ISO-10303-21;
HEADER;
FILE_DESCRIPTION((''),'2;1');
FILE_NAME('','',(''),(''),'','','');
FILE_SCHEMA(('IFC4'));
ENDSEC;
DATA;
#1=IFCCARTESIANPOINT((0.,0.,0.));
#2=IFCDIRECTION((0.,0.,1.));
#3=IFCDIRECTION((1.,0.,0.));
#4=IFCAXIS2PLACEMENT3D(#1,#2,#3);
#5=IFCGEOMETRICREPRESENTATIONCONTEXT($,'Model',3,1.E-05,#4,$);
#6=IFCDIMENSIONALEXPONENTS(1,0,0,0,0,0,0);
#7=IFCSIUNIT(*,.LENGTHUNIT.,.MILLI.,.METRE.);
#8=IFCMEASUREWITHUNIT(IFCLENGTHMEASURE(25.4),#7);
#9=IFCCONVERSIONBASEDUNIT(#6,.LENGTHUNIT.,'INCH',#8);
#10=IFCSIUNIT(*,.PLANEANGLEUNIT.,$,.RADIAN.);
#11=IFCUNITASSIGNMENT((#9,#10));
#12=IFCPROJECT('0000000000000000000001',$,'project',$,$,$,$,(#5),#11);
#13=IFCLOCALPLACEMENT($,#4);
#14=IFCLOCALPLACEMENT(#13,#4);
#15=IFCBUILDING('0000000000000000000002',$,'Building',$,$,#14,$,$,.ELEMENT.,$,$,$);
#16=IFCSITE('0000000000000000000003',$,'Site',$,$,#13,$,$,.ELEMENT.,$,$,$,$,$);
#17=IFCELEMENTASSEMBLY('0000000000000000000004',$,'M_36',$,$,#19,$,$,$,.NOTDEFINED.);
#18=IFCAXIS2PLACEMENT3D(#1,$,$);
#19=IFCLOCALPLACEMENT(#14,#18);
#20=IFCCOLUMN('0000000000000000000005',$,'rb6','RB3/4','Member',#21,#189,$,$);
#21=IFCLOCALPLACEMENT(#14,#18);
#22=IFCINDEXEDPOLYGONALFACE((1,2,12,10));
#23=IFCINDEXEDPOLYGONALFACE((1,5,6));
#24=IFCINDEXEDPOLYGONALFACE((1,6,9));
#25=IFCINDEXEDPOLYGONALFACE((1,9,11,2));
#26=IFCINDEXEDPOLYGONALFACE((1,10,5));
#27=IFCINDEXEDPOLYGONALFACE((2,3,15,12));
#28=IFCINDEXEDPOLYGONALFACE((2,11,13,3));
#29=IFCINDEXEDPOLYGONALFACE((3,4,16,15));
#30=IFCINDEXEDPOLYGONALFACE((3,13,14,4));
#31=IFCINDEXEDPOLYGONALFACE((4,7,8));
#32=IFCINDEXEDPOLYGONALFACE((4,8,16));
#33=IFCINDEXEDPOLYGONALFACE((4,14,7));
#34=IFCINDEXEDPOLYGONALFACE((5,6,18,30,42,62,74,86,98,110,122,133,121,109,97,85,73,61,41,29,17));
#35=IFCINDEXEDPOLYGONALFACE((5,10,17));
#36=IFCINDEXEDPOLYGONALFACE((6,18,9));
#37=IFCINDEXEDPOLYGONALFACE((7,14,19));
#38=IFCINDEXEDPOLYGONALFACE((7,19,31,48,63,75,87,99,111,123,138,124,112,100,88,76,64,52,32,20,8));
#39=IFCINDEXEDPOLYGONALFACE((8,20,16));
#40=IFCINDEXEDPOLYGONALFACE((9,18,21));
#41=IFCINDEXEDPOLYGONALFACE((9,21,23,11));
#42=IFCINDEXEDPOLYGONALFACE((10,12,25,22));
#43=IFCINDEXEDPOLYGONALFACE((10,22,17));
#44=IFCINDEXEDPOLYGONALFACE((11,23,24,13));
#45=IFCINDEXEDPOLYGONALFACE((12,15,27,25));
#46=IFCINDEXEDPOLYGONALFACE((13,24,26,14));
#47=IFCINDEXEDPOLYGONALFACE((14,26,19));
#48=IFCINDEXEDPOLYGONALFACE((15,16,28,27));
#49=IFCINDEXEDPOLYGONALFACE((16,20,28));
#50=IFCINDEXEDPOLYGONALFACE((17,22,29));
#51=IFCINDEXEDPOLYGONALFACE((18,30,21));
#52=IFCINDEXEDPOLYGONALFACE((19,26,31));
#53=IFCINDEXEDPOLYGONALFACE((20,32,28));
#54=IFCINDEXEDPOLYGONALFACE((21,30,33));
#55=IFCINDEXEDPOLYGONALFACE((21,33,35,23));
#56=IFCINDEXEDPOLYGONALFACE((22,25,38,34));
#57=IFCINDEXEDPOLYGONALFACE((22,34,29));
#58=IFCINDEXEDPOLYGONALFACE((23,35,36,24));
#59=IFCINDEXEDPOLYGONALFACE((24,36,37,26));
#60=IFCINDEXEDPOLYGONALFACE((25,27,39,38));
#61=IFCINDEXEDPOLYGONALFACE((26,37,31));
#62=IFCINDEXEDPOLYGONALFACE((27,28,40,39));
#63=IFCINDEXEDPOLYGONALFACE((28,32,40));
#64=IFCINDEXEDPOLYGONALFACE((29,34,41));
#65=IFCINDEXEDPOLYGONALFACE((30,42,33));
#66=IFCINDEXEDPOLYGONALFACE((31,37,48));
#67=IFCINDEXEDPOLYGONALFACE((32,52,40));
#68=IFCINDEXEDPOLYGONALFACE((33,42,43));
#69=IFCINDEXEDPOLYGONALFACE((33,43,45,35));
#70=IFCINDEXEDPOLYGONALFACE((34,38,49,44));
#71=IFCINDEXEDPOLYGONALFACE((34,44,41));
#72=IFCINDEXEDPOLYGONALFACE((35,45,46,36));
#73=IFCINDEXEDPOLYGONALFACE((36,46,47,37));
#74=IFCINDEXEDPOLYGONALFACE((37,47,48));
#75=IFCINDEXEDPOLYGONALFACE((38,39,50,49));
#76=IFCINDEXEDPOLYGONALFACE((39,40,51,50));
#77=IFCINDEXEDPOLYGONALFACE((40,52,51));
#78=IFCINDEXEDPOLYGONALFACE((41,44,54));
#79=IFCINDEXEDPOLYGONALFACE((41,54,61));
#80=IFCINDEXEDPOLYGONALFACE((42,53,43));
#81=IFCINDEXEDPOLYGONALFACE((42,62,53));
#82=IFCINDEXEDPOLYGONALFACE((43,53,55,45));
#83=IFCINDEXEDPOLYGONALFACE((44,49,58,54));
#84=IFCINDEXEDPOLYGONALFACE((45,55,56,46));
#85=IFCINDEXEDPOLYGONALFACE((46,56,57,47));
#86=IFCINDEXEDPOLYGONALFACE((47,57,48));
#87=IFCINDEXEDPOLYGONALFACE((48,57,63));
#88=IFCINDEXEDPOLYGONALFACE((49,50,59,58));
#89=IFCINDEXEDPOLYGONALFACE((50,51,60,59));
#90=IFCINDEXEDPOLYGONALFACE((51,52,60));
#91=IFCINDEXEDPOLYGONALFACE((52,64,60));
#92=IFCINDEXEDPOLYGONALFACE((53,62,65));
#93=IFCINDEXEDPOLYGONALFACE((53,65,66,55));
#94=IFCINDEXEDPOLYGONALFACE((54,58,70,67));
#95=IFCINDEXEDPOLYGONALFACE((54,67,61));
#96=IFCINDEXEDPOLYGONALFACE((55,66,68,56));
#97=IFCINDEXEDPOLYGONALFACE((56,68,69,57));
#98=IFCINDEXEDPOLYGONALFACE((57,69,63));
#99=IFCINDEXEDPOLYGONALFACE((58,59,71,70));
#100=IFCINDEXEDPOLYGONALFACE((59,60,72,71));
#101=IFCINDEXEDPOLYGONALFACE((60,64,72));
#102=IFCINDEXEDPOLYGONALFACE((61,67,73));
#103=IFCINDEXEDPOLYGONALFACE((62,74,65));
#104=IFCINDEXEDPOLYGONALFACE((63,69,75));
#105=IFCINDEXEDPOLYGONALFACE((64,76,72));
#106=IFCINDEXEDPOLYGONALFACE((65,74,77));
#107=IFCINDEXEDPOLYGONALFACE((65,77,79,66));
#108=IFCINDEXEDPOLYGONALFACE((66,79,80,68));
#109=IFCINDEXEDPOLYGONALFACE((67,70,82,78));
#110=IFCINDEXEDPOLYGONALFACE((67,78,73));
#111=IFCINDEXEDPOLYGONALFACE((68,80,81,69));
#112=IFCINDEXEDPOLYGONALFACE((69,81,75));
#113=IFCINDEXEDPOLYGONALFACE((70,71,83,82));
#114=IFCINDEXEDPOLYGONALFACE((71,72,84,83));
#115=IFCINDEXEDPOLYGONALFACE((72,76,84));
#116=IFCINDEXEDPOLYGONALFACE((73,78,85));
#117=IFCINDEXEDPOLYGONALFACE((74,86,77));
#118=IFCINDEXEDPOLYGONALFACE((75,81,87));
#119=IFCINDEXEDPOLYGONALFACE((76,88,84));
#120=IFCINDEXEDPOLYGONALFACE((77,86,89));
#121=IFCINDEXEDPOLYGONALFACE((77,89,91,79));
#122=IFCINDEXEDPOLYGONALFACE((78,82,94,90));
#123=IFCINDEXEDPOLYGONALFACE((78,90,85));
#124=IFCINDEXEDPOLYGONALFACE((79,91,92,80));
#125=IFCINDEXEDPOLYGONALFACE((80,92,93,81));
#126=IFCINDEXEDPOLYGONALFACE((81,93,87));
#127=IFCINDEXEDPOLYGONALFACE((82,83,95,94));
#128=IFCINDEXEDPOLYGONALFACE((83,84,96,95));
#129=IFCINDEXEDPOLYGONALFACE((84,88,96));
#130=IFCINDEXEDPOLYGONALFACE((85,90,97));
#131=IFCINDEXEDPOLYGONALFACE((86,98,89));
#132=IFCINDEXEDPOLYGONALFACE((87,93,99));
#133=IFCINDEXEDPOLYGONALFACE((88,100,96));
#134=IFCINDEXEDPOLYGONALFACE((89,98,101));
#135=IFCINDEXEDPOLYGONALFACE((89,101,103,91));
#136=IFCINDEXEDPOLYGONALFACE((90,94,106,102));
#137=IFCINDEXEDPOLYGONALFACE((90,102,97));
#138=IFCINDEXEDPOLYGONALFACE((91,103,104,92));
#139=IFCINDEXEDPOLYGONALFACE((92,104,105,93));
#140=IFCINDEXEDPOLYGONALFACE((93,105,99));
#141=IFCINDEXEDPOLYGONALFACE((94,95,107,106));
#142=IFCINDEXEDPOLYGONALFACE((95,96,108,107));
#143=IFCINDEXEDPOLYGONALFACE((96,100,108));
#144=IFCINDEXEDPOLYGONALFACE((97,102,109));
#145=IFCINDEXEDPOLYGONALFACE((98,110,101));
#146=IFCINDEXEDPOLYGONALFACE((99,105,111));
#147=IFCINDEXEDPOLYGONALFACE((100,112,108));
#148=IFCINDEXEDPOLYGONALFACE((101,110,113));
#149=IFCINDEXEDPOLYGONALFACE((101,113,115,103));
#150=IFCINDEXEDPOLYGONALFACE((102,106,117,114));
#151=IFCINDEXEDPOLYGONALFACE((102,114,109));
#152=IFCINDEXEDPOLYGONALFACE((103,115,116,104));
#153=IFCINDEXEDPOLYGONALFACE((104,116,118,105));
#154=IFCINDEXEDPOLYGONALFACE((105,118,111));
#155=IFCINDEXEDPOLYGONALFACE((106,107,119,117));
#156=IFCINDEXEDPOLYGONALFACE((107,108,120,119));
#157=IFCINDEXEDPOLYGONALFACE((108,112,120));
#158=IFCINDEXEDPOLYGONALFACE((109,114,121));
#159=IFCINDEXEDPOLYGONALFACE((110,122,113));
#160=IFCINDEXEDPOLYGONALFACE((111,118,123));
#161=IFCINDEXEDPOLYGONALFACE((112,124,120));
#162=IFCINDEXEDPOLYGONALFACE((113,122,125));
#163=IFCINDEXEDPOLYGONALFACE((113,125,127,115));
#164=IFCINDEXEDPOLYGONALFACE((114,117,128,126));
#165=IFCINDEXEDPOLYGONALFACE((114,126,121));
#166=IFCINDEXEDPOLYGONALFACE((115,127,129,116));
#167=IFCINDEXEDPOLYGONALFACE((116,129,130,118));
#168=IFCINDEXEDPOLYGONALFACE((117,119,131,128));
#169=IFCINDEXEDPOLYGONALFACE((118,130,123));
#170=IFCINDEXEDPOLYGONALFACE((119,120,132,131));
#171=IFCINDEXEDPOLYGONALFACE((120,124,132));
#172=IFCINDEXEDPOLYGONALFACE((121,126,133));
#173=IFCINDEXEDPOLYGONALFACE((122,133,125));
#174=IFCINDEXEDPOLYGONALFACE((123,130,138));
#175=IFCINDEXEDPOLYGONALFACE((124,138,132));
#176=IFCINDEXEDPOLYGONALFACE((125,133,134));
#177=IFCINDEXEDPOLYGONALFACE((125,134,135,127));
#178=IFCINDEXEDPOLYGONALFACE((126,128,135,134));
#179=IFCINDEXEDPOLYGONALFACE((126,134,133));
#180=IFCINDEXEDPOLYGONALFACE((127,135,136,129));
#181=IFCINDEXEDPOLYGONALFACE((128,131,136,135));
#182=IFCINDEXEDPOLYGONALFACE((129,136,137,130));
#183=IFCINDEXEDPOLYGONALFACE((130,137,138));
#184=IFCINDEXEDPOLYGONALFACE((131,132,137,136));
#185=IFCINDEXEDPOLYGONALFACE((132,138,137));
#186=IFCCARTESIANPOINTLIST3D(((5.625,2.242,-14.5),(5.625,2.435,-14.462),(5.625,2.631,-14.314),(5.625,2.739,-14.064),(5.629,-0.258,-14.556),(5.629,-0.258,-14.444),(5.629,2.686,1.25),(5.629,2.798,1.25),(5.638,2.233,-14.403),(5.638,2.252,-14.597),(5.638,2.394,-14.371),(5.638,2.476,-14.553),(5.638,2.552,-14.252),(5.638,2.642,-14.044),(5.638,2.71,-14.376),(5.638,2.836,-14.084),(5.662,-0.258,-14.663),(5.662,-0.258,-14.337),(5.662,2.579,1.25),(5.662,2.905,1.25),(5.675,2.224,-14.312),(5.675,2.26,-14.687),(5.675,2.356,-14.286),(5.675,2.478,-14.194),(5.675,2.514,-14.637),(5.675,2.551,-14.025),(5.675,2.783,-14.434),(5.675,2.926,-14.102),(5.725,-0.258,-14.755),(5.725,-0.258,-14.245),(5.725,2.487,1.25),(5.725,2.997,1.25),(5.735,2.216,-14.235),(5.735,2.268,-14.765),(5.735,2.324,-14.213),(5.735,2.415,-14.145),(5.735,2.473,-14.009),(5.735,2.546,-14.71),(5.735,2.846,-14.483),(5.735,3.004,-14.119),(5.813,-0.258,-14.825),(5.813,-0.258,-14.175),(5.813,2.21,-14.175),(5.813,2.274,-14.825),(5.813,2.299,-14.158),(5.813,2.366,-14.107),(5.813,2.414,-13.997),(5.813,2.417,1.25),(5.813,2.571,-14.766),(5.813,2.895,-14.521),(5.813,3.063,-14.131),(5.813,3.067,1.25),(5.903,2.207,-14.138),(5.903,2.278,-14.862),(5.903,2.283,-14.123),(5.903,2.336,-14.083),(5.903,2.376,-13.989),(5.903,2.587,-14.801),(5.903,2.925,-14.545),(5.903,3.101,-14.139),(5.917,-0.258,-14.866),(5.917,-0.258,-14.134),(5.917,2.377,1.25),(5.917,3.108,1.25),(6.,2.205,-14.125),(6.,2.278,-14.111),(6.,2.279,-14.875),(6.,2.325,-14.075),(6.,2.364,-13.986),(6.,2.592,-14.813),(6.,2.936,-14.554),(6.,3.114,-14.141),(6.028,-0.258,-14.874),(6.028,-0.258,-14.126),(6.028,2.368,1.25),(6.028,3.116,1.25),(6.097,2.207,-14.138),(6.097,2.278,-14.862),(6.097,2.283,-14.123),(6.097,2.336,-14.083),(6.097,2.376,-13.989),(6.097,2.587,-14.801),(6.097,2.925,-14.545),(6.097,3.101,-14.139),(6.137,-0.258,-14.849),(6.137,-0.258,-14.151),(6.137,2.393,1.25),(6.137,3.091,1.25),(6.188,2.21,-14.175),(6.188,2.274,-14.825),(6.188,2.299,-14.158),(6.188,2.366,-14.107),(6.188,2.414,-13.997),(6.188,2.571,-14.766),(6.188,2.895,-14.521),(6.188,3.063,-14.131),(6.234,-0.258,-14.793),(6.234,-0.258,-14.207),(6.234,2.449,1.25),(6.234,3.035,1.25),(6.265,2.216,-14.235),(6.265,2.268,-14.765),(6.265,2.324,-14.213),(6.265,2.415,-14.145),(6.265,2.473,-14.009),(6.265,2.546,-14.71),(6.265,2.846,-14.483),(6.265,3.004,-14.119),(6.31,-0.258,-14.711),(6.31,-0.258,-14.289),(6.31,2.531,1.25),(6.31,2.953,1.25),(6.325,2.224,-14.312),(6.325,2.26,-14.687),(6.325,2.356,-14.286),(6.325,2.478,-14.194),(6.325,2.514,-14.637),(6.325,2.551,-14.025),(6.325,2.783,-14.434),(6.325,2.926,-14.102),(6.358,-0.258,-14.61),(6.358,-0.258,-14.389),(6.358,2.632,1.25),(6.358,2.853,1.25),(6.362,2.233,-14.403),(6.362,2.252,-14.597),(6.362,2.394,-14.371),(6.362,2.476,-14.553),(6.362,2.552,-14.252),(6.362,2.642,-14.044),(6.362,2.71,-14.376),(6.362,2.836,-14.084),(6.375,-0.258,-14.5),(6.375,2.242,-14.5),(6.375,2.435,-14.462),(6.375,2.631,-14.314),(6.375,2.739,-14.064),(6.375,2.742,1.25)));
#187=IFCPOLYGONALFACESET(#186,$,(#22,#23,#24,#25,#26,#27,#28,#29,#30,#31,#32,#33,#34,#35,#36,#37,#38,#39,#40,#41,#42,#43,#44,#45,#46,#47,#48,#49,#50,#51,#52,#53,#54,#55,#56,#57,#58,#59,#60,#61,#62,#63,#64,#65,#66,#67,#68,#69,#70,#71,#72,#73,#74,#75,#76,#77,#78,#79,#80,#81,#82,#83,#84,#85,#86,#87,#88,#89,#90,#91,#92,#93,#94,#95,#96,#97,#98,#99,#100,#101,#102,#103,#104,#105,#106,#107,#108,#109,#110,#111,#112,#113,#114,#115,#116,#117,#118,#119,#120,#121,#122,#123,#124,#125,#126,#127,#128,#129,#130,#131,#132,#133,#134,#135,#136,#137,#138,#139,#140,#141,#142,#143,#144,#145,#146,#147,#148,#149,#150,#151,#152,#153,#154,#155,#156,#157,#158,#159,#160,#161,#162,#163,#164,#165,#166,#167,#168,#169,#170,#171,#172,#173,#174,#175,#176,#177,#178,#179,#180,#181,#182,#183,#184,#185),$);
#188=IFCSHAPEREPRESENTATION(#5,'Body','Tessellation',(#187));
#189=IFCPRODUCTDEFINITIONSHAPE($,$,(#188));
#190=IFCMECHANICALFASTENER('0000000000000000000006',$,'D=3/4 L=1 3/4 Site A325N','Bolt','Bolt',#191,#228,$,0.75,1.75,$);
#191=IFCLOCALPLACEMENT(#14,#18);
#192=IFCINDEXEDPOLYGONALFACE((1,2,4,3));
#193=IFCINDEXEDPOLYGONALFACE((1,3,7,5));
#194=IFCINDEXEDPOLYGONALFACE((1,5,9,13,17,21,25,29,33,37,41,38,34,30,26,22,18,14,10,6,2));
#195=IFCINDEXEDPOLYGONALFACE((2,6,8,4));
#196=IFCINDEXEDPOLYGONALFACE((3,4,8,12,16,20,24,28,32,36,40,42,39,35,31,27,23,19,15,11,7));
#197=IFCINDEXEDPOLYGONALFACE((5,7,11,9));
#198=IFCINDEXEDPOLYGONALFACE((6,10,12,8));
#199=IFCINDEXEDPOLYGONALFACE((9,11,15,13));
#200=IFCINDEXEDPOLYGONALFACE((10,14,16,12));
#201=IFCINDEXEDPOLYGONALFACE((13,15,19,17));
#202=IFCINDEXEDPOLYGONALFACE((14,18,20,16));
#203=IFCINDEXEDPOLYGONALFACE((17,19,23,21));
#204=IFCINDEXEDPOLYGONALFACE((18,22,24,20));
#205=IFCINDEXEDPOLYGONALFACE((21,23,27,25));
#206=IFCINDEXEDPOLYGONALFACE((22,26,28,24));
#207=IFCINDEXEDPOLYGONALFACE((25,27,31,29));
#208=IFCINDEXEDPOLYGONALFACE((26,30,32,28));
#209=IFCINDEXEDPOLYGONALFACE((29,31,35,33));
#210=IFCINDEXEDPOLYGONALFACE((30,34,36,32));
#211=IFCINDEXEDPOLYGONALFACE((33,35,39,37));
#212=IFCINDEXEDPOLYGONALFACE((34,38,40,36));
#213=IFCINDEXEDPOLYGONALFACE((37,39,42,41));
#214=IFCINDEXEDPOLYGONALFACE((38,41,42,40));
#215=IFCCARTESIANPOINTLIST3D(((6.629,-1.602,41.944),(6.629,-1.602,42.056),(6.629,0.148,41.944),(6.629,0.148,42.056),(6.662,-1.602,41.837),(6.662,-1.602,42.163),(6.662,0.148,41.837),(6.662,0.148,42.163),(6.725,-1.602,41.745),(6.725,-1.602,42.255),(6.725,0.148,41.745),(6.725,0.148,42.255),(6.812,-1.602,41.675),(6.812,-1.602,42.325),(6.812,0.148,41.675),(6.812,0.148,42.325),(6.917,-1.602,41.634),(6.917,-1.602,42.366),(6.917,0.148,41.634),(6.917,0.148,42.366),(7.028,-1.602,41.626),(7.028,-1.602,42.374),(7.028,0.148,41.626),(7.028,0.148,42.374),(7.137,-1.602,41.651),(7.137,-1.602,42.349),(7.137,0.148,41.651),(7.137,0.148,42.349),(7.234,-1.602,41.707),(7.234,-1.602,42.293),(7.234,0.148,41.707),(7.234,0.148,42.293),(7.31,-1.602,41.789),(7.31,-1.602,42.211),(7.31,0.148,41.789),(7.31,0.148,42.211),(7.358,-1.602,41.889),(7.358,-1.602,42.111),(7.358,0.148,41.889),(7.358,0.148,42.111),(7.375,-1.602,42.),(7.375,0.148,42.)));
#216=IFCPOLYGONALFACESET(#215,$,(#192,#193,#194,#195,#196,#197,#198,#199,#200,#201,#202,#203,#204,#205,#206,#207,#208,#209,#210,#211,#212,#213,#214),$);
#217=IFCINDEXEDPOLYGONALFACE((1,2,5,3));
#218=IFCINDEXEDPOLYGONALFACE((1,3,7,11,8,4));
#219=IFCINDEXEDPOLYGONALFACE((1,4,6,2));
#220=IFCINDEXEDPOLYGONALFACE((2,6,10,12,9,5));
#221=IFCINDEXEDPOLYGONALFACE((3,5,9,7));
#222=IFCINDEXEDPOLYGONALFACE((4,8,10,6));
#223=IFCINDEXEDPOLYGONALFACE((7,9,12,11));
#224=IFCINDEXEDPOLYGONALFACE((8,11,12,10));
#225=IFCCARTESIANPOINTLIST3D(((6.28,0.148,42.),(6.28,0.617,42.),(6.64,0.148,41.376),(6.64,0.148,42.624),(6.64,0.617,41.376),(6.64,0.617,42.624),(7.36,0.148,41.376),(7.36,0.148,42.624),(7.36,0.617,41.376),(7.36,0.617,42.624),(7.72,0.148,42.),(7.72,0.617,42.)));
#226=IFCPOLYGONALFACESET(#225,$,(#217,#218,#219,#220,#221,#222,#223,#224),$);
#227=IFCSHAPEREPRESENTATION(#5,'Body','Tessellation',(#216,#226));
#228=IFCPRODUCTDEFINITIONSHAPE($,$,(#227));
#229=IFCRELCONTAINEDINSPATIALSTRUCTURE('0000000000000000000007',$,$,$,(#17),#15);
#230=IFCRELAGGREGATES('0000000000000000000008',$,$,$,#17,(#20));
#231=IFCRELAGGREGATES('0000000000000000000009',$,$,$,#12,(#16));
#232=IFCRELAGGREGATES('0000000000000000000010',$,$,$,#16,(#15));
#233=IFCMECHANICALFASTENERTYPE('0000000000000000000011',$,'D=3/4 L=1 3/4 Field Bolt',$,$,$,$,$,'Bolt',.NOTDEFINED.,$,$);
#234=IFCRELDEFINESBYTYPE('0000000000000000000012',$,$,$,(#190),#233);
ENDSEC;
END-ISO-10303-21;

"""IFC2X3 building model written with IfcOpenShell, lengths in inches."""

from ifc_helpers import new_model, entity, si_unit, converted_unit, frame, origin_with_axes, origin_2d_with_axis, place, context, project, spatial, polyline, circle, outline, extrude, source, transform, mapped, type_object, type_shapes, element, aggregate, save


model = new_model("IFC2X3")

# Units and contexts
model_context = context("Model", 3, precision=1e-05, world=origin_with_axes())
ifc_project = project(units=[converted_unit("LENGTHUNIT", "INCH", entity("IfcLengthMeasure", 25.4), si_unit("LENGTHUNIT", "METRE", prefix="MILLI"), dimensions=[1, 0, 0, 0, 0, 0, 0]), si_unit("PLANEANGLEUNIT", "RADIAN")], contexts=[model_context])

# Site, building
site_placement = place(None, origin_with_axes())
site = spatial("IfcSite", under=ifc_project, at=site_placement, Name="Site", CompositionType="ELEMENT")
building_placement = place(site_placement, origin_with_axes())
building = spatial("IfcBuilding", under=site, at=building_placement, Name="Building", CompositionType="ELEMENT")

# Element assembly, column
assembly_1_placement = place(building_placement, frame((3.0, 0.0, -22.668), z_axis=(0.0, -1.0, 0.0), x_axis=(0.0, 0.0, 1.0)))
assembly_1 = element("IfcElementAssembly", 1, at=assembly_1_placement, inside=building, Name="M_36", PredefinedType="NOTDEFINED")
column_1_placement = place(assembly_1_placement, frame((8.44, -3.0, 0.258), z_axis=(0.0, -1.0, 0.0), x_axis=(-1.0, 0.0, 0.0)))
cartesian_point_1 = entity("IfcCartesianPoint", [0.0, 0.0, 0.0])
ifc_direction_1 = entity("IfcDirection", [0.0, 0.0, 1.0])
ifc_direction_2 = entity("IfcDirection", [1.0, 0.0, 0.0])
column_1 = element("IfcColumn", 2, at=column_1_placement, Name="rb6", Description="RB3/4", ObjectType="Member", context=model_context, shape_type="SweptSolid", body=[
    entity("IfcSurfaceCurveSweptAreaSolid", entity("IfcCircleProfileDef", "AREA", None, entity("IfcAxis2Placement2D", entity("IfcCartesianPoint", [0.0, 0.0]), entity("IfcDirection", [1.0, 0.0])), 0.375), entity("IfcAxis2Placement3D", cartesian_point_1, ifc_direction_1, ifc_direction_2), entity("IfcPolyline", [entity("IfcCartesianPoint", [0.272, 0.0]), entity("IfcCartesianPoint", [0.272, 2.5]), entity("IfcCartesianPoint", [0.234, 2.693]), entity("IfcCartesianPoint", [0.086, 2.888]), entity("IfcCartesianPoint", [-0.164, 2.996]), entity("IfcCartesianPoint", [-15.478, 3.0])]), 0.0, 1.0, entity("IfcPlane", entity("IfcAxis2Placement3D", cartesian_point_1, ifc_direction_1, ifc_direction_2))),
])
aggregate(assembly_1, [column_1])

# Mechanical fastener
mechanical_fastener_type_1 = type_object("IfcMechanicalFastenerType", Name="D=3/4 L=1 3/4 Field Bolt", ElementType="Bolt")
shared_shape_1 = source(origin_with_axes(), model_context, "Body", "SweptSolid", [
    extrude(circle(Radius=0.375, at=origin_2d_with_axis()), frame((0.0, 0.0, 0.0), z_axis=(1.0, 0.0, 0.0), x_axis=(0.0, 1.0, 0.0)), (0.0, 0.0, 1.0), 1.75),
    extrude(outline(polyline([(-0.72, 0.0), (-0.36, 0.624), (0.36, 0.624), (0.72, 0.0), (0.36, -0.624), (-0.36, -0.624), (-0.72, 0.0)])), frame((0.0, 0.0, 0.0), z_axis=(1.0, 0.0, 0.0), x_axis=(0.0, 1.0, 0.0)), (0.0, 0.0, -1.0), 0.47),
])
type_shapes(mechanical_fastener_type_1, [shared_shape_1])
placement_1 = place(building_placement, frame((0.0, 0.0, 46.0), z_axis=(0.0, 0.0, 1.0), x_axis=(1.0, 0.0, 0.0)))
placement_2 = place(placement_1, frame((7.0, 0.148, -4.0), z_axis=(0.0, 0.0, 1.0), x_axis=(0.0, -1.0, 0.0)))
for number, where, z_axis, x_axis, name in (
    (3, (0.0, 0.0, 0.0), (0.0, 0.0, 1.0), (1.0, 0.0, 0.0), "D=3/4 L=1 3/4 Site A325N"),
):
    element("IfcMechanicalFastener", number, at=place(placement_2, frame(where, z_axis=z_axis, x_axis=x_axis)), type_object=mechanical_fastener_type_1, Name=name, Description="Bolt", ObjectType="Bolt", NominalDiameter=0.75, NominalLength=1.75, context=model_context, shape_type="MappedRepresentation", body=[
        mapped(shared_shape_1, transform((0.0, 0.0, 0.0), scale=1.0)),
    ])

save(model, "model.ifc")
